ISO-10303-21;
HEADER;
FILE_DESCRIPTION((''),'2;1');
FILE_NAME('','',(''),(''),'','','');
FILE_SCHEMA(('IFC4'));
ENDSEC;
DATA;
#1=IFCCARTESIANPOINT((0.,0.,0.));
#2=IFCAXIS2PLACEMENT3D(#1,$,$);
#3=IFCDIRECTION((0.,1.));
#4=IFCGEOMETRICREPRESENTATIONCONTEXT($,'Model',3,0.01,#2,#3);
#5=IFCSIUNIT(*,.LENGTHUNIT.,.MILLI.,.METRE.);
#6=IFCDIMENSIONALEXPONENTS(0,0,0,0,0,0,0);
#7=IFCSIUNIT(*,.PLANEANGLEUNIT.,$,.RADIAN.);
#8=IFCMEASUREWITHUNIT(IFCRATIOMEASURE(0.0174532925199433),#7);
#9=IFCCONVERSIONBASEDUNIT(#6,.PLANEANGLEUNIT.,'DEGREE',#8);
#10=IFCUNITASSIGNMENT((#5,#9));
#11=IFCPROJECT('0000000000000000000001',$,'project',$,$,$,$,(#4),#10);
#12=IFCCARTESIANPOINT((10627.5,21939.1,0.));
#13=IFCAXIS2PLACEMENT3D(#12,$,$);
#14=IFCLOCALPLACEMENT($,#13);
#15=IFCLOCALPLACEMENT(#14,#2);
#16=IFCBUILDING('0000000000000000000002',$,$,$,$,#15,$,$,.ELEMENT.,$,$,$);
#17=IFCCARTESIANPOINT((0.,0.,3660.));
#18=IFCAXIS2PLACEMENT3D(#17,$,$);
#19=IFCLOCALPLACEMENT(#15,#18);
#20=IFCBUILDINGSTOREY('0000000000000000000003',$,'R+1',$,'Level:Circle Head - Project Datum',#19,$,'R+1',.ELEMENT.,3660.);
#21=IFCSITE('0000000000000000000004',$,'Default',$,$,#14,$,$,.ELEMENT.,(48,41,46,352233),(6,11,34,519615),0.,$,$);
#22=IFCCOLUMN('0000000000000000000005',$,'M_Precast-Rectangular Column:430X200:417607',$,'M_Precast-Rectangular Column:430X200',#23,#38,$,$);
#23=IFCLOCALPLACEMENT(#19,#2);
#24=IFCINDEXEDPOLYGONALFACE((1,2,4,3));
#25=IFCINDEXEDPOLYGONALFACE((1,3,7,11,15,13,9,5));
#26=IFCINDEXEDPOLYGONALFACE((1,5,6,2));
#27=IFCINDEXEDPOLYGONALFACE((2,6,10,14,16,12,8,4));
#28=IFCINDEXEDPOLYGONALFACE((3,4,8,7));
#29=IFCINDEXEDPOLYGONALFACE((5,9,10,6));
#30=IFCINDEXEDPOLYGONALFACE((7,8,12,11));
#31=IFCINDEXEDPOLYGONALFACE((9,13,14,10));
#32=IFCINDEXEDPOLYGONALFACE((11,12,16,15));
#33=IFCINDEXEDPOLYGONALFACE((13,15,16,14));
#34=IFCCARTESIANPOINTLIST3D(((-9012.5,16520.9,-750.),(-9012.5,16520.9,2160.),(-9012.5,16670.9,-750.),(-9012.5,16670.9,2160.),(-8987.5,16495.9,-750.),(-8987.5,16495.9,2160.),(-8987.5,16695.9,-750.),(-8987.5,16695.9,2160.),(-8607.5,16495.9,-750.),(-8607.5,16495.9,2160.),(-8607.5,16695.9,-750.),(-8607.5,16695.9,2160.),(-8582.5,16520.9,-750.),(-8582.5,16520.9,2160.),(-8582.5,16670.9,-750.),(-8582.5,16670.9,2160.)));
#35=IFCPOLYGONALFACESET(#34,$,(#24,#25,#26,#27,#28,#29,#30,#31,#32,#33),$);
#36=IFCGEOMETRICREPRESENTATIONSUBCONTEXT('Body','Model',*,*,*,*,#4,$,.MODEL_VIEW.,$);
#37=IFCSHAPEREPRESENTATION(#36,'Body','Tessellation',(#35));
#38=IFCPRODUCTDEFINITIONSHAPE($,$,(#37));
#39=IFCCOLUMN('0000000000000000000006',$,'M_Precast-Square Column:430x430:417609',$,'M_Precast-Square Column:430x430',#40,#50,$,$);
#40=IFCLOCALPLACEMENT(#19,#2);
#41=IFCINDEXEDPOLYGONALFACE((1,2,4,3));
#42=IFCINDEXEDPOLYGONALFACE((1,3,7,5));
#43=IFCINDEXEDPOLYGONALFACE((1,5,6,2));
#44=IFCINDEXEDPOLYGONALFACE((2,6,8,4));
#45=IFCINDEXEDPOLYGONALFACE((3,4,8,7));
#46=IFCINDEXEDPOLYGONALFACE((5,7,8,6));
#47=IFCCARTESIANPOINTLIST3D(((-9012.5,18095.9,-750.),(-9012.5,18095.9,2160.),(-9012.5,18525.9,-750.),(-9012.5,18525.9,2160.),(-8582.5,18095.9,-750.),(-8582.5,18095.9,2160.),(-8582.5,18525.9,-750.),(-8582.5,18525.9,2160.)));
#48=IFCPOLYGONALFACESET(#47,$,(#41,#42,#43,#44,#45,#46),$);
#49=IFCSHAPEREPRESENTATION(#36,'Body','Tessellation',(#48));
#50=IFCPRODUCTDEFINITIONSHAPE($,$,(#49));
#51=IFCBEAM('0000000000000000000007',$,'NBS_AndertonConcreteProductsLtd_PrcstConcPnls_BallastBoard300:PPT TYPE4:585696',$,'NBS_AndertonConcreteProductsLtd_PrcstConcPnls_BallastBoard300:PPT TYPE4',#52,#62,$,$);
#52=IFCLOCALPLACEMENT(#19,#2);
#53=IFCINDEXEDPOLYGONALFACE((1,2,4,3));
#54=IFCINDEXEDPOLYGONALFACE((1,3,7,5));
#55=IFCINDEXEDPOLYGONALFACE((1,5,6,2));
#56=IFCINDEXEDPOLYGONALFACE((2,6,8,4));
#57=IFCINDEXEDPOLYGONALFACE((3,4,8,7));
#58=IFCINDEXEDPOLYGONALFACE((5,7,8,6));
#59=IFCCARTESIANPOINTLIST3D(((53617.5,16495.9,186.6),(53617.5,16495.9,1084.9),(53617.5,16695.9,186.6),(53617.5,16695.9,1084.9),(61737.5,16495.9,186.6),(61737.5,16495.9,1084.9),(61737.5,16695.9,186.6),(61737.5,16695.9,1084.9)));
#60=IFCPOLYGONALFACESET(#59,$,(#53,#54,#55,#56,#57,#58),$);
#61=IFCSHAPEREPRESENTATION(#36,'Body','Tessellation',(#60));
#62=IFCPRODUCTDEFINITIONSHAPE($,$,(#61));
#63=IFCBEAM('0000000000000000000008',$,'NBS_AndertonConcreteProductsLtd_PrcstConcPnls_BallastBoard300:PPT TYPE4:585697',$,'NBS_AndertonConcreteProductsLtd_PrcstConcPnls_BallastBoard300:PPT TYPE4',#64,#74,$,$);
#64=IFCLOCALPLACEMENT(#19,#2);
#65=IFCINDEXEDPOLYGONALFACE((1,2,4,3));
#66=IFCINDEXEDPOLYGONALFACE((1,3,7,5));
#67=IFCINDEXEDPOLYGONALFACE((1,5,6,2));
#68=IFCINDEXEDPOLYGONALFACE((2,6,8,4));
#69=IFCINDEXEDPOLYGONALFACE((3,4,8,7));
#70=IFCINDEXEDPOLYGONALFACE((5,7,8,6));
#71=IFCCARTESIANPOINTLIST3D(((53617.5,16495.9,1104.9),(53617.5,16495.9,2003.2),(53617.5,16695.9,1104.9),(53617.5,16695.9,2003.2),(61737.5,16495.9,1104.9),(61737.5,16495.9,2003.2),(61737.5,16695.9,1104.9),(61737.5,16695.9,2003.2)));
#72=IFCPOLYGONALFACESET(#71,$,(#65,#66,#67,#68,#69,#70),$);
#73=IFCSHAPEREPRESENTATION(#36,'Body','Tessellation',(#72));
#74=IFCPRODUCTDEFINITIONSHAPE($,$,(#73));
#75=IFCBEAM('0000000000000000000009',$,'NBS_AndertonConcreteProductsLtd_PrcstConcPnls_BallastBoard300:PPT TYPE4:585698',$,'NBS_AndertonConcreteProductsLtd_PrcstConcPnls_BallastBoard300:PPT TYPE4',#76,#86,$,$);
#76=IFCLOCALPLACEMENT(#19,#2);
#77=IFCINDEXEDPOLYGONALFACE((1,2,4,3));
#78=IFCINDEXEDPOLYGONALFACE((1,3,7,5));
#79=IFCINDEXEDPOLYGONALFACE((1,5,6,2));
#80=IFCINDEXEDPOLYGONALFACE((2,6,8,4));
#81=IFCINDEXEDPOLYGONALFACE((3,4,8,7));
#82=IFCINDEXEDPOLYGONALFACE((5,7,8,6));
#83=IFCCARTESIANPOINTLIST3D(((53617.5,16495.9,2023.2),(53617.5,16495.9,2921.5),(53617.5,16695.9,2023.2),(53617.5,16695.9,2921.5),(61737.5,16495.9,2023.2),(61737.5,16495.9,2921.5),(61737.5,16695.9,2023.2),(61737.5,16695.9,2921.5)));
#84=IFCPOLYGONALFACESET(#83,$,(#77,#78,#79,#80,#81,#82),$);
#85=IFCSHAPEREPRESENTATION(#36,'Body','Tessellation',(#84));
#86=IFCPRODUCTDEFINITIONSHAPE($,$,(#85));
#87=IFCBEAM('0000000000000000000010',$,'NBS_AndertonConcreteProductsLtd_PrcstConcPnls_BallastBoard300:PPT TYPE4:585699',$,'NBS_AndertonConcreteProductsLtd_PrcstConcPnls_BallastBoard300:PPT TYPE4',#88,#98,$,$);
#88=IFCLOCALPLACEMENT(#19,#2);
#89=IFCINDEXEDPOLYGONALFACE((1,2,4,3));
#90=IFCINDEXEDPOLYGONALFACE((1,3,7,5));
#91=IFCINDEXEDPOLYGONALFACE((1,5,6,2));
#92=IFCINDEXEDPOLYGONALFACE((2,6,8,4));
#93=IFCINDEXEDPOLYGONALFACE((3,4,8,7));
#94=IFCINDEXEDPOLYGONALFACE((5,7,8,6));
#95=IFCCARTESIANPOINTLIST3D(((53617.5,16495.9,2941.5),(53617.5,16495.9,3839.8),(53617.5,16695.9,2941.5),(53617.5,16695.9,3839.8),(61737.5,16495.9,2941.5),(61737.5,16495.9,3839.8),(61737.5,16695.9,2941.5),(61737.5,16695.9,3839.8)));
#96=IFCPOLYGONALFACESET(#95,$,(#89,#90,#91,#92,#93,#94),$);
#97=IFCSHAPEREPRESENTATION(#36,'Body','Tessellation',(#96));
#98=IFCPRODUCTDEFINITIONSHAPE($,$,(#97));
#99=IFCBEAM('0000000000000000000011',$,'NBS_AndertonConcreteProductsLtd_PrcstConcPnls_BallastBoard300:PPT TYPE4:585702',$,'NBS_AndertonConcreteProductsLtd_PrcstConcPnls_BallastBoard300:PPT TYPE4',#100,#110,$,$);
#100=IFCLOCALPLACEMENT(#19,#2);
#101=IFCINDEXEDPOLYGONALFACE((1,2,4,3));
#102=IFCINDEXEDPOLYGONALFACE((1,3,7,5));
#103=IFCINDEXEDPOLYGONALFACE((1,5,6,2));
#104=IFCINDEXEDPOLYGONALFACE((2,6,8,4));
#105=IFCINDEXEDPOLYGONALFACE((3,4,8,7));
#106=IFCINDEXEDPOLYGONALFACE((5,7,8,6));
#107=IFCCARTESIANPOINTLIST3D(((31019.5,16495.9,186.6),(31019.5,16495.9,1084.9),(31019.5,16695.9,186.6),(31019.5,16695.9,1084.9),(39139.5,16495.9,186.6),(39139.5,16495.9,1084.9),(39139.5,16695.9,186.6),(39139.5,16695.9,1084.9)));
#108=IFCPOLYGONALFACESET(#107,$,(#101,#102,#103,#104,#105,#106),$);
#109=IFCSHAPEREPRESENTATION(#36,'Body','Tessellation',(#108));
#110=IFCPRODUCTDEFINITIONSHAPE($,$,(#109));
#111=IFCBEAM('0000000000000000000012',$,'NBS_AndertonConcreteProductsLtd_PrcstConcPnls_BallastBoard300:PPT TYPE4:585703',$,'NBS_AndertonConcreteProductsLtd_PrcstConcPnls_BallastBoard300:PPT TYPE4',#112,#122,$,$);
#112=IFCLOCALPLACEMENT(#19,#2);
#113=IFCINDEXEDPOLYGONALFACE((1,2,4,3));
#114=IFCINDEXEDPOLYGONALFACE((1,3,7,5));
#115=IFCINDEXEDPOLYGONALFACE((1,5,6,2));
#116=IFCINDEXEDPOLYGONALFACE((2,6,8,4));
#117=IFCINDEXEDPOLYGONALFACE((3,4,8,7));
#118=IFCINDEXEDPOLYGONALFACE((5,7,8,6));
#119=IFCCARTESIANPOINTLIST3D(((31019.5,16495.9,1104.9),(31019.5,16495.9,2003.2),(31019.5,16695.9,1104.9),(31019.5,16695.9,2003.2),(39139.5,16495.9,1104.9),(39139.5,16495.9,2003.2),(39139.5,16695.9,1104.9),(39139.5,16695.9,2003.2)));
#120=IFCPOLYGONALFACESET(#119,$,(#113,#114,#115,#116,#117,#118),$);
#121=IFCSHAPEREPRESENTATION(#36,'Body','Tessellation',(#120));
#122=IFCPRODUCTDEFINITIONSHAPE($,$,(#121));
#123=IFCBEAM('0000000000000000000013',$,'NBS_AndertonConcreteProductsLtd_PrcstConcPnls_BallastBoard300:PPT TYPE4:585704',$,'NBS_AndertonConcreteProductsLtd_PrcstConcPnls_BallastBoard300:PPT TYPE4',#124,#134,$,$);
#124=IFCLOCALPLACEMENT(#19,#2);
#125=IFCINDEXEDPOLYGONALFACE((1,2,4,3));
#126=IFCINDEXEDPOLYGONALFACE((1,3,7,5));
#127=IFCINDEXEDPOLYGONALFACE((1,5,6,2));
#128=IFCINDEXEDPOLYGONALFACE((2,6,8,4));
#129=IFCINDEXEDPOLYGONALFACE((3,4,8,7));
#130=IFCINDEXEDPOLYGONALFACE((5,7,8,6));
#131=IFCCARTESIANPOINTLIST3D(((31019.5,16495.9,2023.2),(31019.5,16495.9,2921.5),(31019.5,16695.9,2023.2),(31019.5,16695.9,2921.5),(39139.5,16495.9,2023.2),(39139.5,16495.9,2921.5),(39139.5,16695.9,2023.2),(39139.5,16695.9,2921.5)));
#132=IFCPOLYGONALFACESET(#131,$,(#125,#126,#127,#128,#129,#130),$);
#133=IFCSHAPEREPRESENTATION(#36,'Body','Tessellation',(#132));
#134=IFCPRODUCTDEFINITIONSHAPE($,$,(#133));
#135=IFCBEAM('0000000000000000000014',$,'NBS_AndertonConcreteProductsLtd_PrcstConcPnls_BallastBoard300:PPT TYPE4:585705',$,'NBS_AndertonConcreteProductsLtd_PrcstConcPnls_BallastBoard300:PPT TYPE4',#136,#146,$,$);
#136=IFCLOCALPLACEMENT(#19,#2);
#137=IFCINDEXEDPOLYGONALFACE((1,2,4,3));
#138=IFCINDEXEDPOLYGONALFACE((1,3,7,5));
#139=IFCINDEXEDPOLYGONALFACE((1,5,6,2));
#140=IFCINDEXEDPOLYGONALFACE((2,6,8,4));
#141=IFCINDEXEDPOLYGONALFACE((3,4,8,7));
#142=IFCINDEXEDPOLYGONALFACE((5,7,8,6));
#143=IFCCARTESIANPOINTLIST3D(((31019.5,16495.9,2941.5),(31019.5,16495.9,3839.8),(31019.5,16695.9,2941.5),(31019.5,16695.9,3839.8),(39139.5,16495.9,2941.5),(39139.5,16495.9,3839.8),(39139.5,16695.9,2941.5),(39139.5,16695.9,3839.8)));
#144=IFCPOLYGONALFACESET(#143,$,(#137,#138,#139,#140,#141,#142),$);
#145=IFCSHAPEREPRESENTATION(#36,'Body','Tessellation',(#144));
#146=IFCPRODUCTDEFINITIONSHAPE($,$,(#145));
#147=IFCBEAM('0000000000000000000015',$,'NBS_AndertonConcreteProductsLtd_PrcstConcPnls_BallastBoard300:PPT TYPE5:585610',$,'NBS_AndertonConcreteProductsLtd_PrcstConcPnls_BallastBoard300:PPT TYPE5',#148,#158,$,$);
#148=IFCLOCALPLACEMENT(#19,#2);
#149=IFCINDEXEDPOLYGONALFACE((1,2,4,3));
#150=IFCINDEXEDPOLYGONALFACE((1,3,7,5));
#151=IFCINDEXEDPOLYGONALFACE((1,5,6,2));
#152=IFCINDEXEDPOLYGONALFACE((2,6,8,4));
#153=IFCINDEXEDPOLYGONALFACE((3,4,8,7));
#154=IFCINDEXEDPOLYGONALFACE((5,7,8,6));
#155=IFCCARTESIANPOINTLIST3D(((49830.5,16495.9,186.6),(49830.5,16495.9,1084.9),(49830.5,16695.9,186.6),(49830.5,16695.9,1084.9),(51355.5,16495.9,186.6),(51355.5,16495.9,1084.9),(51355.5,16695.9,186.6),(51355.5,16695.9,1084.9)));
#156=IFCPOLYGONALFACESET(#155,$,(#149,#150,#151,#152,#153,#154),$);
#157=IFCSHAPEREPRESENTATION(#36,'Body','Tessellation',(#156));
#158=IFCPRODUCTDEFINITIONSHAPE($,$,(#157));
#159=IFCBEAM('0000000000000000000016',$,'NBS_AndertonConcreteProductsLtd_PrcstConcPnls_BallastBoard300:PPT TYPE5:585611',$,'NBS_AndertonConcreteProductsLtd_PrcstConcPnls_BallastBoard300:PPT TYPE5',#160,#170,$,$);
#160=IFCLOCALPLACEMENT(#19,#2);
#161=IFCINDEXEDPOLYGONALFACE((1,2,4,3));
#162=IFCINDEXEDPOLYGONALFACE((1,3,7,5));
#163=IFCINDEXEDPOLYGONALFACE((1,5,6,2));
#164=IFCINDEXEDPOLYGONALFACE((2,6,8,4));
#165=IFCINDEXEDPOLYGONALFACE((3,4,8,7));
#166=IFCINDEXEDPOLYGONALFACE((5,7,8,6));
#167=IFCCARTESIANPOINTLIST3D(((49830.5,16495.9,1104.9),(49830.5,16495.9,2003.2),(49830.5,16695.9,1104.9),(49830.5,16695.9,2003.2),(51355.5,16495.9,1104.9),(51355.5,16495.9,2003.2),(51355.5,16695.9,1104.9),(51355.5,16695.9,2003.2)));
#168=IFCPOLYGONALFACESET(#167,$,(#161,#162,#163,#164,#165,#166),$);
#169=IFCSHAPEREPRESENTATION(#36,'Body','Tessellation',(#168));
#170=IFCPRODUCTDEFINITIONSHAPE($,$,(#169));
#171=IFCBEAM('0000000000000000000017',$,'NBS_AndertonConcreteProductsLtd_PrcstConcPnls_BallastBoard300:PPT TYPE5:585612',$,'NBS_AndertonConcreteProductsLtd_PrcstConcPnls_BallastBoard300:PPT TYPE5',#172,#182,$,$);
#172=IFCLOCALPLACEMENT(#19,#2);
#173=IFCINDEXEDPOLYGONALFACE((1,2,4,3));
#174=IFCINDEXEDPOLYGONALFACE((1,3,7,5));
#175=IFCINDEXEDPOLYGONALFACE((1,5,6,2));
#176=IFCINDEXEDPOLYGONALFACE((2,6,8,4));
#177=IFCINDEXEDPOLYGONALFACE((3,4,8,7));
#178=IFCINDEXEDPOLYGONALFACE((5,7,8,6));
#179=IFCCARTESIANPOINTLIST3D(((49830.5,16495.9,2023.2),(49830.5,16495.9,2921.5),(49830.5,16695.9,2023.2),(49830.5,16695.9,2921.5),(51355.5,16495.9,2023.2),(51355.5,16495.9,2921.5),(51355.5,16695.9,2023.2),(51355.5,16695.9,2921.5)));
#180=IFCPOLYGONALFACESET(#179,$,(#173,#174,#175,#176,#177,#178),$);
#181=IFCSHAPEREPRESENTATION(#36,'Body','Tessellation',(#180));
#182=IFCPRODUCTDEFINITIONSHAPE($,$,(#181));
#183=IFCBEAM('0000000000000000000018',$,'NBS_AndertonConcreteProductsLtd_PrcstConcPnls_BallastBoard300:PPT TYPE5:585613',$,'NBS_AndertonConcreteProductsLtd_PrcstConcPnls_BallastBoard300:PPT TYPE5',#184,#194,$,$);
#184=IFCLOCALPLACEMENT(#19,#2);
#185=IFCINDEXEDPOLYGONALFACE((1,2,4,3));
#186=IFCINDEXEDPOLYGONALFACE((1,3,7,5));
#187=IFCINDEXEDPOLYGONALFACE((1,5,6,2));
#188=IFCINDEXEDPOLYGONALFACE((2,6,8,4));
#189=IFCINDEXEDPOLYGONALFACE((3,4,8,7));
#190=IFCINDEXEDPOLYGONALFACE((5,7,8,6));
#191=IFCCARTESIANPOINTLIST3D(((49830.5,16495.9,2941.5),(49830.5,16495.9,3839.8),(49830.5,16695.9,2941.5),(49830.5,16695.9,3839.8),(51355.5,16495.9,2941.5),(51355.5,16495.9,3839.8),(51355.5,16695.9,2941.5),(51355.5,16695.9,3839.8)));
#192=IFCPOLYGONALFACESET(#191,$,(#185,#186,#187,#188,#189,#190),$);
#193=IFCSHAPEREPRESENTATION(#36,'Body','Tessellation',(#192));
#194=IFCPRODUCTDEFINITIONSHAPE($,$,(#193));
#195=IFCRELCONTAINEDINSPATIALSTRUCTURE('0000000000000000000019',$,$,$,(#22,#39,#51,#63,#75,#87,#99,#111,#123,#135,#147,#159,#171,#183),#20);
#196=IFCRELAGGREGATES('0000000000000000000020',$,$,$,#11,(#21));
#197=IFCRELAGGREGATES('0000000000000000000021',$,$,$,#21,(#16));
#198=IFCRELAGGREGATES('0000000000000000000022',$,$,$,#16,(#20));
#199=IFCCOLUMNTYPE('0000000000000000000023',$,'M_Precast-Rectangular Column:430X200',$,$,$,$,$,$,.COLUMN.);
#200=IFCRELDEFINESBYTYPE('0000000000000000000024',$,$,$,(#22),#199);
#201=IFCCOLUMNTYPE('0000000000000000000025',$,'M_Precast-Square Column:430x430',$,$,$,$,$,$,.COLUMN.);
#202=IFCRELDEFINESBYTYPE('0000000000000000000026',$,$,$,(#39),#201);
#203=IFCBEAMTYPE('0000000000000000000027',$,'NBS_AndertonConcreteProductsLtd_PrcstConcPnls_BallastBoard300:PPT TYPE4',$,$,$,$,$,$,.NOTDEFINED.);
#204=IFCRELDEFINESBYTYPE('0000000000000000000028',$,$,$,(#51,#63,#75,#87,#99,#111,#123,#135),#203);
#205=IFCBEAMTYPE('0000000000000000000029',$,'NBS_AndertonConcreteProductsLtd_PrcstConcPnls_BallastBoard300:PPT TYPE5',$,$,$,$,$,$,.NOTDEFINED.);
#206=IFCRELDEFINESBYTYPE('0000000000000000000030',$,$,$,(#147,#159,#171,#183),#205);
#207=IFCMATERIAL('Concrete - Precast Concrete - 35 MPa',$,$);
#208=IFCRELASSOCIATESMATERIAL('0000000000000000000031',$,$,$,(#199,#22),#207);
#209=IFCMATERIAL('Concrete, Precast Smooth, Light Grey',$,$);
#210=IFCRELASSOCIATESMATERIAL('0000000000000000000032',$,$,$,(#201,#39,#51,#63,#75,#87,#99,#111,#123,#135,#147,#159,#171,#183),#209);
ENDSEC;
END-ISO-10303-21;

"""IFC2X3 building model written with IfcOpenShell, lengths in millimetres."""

from ifc_helpers import new_model, entity, si_unit, converted_unit, direction, frame, frame_2d, origin, origin_2d_with_axis, place, context, subcontext, project, spatial, polyline, rectangle, outline, extrude, source, transform, mapped, material, type_object, type_shapes, element, save


model = new_model("IFC2X3")

# Units and contexts
model_context = context("Model", 3, precision=0.01, world=origin(), true_north=direction((0.0, 1.0)))
body_context = subcontext(model_context, "Body", "Model", "MODEL_VIEW")
ifc_project = project(units=[si_unit("LENGTHUNIT", "METRE", prefix="MILLI"), converted_unit("PLANEANGLEUNIT", "DEGREE", entity("IfcRatioMeasure", 0.0174532925199433), si_unit("PLANEANGLEUNIT", "RADIAN"), dimensions=[0, 0, 0, 0, 0, 0, 0])], contexts=[model_context])

# Site, building, storey
site_placement = place(None, frame((10627.5, 21939.1, 0.0)))
site = spatial("IfcSite", under=ifc_project, at=site_placement, Name="Default", CompositionType="ELEMENT", RefLatitude=(48, 41, 46, 352233), RefLongitude=(6, 11, 34, 519615), RefElevation=0.0)
building_placement = place(site_placement, origin())
building = spatial("IfcBuilding", under=site, at=building_placement, CompositionType="ELEMENT")
storey_placement = place(building_placement, frame((0.0, 0.0, 3660.0)))
storey = spatial("IfcBuildingStorey", under=building, at=storey_placement, Name="R+1", ObjectType="Level:Circle Head - Project Datum", LongName="R+1", CompositionType="ELEMENT", Elevation=3660.0)

# Columns
ifc_material_1 = material(Name="Concrete - Precast Concrete - 35 MPa")
column_type_1 = type_object("IfcColumnType", Name="M_Precast-Rectangular Column:430X200", PredefinedType="COLUMN", material=ifc_material_1)
shared_shape_1 = source(origin(), body_context, "Body", "SweptSolid", [
    extrude(outline(polyline([(-75.0, -215.0), (75.0, -215.0), (100.0, -190.0), (100.0, 190.0), (75.0, 215.0), (-75.0, 215.0), (-100.0, 190.0), (-100.0, -190.0), (-75.0, -215.0)])), frame((0.0, 0.0, 2910.0), z_axis=(0.0, 0.0, 1.0), x_axis=(0.0, -1.0, 0.0)), (0.0, 0.0, 1.0), 2910.0),
])
type_shapes(column_type_1, [shared_shape_1])
column_1_placement = place(storey_placement, frame((-8797.5, 16595.9, -3660.0), z_axis=(0.0, 0.0, 1.0), x_axis=(-1.0, 0.0, 0.0)))
element("IfcColumn", 1, at=column_1_placement, inside=storey, type_object=column_type_1, material=ifc_material_1, Name="M_Precast-Rectangular Column:430X200:417607", ObjectType="M_Precast-Rectangular Column:430X200", context=body_context, shape_type="MappedRepresentation", body=[
    mapped(shared_shape_1, transform((0.0, 0.0, 0.0), scale=1.0)),
])
ifc_material_2 = material(Name="Concrete, Precast Smooth, Light Grey")
column_type_2 = type_object("IfcColumnType", Name="M_Precast-Square Column:430x430", PredefinedType="COLUMN", material=ifc_material_2)
shared_shape_2 = source(origin(), body_context, "Body", "SweptSolid", [
    extrude(rectangle(XDim=430.0, YDim=430.0, at=origin_2d_with_axis()), frame((0.0, 0.0, 2910.0), z_axis=(0.0, 0.0, 1.0), x_axis=(0.0, -1.0, 0.0)), (0.0, 0.0, 1.0), 2910.0),
])
type_shapes(column_type_2, [shared_shape_2])
column_2_placement = place(storey_placement, frame((-8797.5, 18310.9, -3660.0), z_axis=(0.0, 0.0, 1.0), x_axis=(-1.0, 0.0, 0.0)))
element("IfcColumn", 2, at=column_2_placement, inside=storey, type_object=column_type_2, material=ifc_material_2, Name="M_Precast-Square Column:430x430:417609", ObjectType="M_Precast-Square Column:430x430", context=body_context, shape_type="MappedRepresentation", body=[
    mapped(shared_shape_2, transform((0.0, 0.0, 0.0), scale=1.0)),
])

# Beams
beam_type_1 = type_object("IfcBeamType", Name="NBS_AndertonConcreteProductsLtd_PrcstConcPnls_BallastBoard300:PPT TYPE4", PredefinedType="NOTDEFINED")
beam_1_placement = place(storey_placement, origin())
element("IfcBeam", 3, at=beam_1_placement, inside=storey, type_object=beam_type_1, material=ifc_material_2, Name="NBS_AndertonConcreteProductsLtd_PrcstConcPnls_BallastBoard300:PPT TYPE4:585696", ObjectType="NBS_AndertonConcreteProductsLtd_PrcstConcPnls_BallastBoard300:PPT TYPE4", context=body_context, shape_type="SweptSolid", body=[
    extrude(rectangle(XDim=898.3, YDim=200.0, at=frame_2d((0.0, 0.0), x_axis=(1.0, 0.0))), frame((53617.5, 16595.9, 635.8), z_axis=(1.0, 0.0, 0.0), x_axis=(0.0, 0.0, -1.0)), (0.0, 0.0, 1.0), 8120.0),
])
beam_2_placement = place(storey_placement, origin())
element("IfcBeam", 4, at=beam_2_placement, inside=storey, type_object=beam_type_1, material=ifc_material_2, Name="NBS_AndertonConcreteProductsLtd_PrcstConcPnls_BallastBoard300:PPT TYPE4:585697", ObjectType="NBS_AndertonConcreteProductsLtd_PrcstConcPnls_BallastBoard300:PPT TYPE4", context=body_context, shape_type="SweptSolid", body=[
    extrude(rectangle(XDim=898.3, YDim=200.0, at=frame_2d((0.0, 0.0), x_axis=(1.0, 0.0))), frame((53617.5, 16595.9, 1554.1), z_axis=(1.0, 0.0, 0.0), x_axis=(0.0, 0.0, -1.0)), (0.0, 0.0, 1.0), 8120.0),
])
beam_3_placement = place(storey_placement, origin())
element("IfcBeam", 5, at=beam_3_placement, inside=storey, type_object=beam_type_1, material=ifc_material_2, Name="NBS_AndertonConcreteProductsLtd_PrcstConcPnls_BallastBoard300:PPT TYPE4:585698", ObjectType="NBS_AndertonConcreteProductsLtd_PrcstConcPnls_BallastBoard300:PPT TYPE4", context=body_context, shape_type="SweptSolid", body=[
    extrude(rectangle(XDim=898.3, YDim=200.0, at=frame_2d((0.0, 0.0), x_axis=(1.0, 0.0))), frame((53617.5, 16595.9, 2472.4), z_axis=(1.0, 0.0, 0.0), x_axis=(0.0, 0.0, -1.0)), (0.0, 0.0, 1.0), 8120.0),
])
beam_4_placement = place(storey_placement, origin())
element("IfcBeam", 6, at=beam_4_placement, inside=storey, type_object=beam_type_1, material=ifc_material_2, Name="NBS_AndertonConcreteProductsLtd_PrcstConcPnls_BallastBoard300:PPT TYPE4:585699", ObjectType="NBS_AndertonConcreteProductsLtd_PrcstConcPnls_BallastBoard300:PPT TYPE4", context=body_context, shape_type="SweptSolid", body=[
    extrude(rectangle(XDim=898.3, YDim=200.0, at=frame_2d((0.0, 0.0), x_axis=(1.0, 0.0))), frame((53617.5, 16595.9, 3390.7), z_axis=(1.0, 0.0, 0.0), x_axis=(0.0, 0.0, -1.0)), (0.0, 0.0, 1.0), 8120.0),
])
beam_5_placement = place(storey_placement, origin())
element("IfcBeam", 7, at=beam_5_placement, inside=storey, type_object=beam_type_1, material=ifc_material_2, Name="NBS_AndertonConcreteProductsLtd_PrcstConcPnls_BallastBoard300:PPT TYPE4:585702", ObjectType="NBS_AndertonConcreteProductsLtd_PrcstConcPnls_BallastBoard300:PPT TYPE4", context=body_context, shape_type="SweptSolid", body=[
    extrude(rectangle(XDim=898.3, YDim=200.0, at=frame_2d((0.0, 0.0), x_axis=(1.0, 0.0))), frame((31019.5, 16595.9, 635.8), z_axis=(1.0, 0.0, 0.0), x_axis=(0.0, 0.0, -1.0)), (0.0, 0.0, 1.0), 8120.0),
])
beam_6_placement = place(storey_placement, origin())
element("IfcBeam", 8, at=beam_6_placement, inside=storey, type_object=beam_type_1, material=ifc_material_2, Name="NBS_AndertonConcreteProductsLtd_PrcstConcPnls_BallastBoard300:PPT TYPE4:585703", ObjectType="NBS_AndertonConcreteProductsLtd_PrcstConcPnls_BallastBoard300:PPT TYPE4", context=body_context, shape_type="SweptSolid", body=[
    extrude(rectangle(XDim=898.3, YDim=200.0, at=frame_2d((0.0, 0.0), x_axis=(1.0, 0.0))), frame((31019.5, 16595.9, 1554.1), z_axis=(1.0, 0.0, 0.0), x_axis=(0.0, 0.0, -1.0)), (0.0, 0.0, 1.0), 8120.0),
])
beam_7_placement = place(storey_placement, origin())
element("IfcBeam", 9, at=beam_7_placement, inside=storey, type_object=beam_type_1, material=ifc_material_2, Name="NBS_AndertonConcreteProductsLtd_PrcstConcPnls_BallastBoard300:PPT TYPE4:585704", ObjectType="NBS_AndertonConcreteProductsLtd_PrcstConcPnls_BallastBoard300:PPT TYPE4", context=body_context, shape_type="SweptSolid", body=[
    extrude(rectangle(XDim=898.3, YDim=200.0, at=frame_2d((0.0, 0.0), x_axis=(1.0, 0.0))), frame((31019.5, 16595.9, 2472.4), z_axis=(1.0, 0.0, 0.0), x_axis=(0.0, 0.0, -1.0)), (0.0, 0.0, 1.0), 8120.0),
])
beam_8_placement = place(storey_placement, origin())
element("IfcBeam", 10, at=beam_8_placement, inside=storey, type_object=beam_type_1, material=ifc_material_2, Name="NBS_AndertonConcreteProductsLtd_PrcstConcPnls_BallastBoard300:PPT TYPE4:585705", ObjectType="NBS_AndertonConcreteProductsLtd_PrcstConcPnls_BallastBoard300:PPT TYPE4", context=body_context, shape_type="SweptSolid", body=[
    extrude(rectangle(XDim=898.3, YDim=200.0, at=frame_2d((0.0, 0.0), x_axis=(1.0, 0.0))), frame((31019.5, 16595.9, 3390.7), z_axis=(1.0, 0.0, 0.0), x_axis=(0.0, 0.0, -1.0)), (0.0, 0.0, 1.0), 8120.0),
])
beam_type_2 = type_object("IfcBeamType", Name="NBS_AndertonConcreteProductsLtd_PrcstConcPnls_BallastBoard300:PPT TYPE5", PredefinedType="NOTDEFINED")
beam_9_placement = place(storey_placement, origin())
element("IfcBeam", 11, at=beam_9_placement, inside=storey, type_object=beam_type_2, material=ifc_material_2, Name="NBS_AndertonConcreteProductsLtd_PrcstConcPnls_BallastBoard300:PPT TYPE5:585610", ObjectType="NBS_AndertonConcreteProductsLtd_PrcstConcPnls_BallastBoard300:PPT TYPE5", context=body_context, shape_type="SweptSolid", body=[
    extrude(rectangle(XDim=898.3, YDim=200.0, at=frame_2d((0.0, 0.0), x_axis=(1.0, 0.0))), frame((49830.5, 16595.9, 635.8), z_axis=(1.0, 0.0, 0.0), x_axis=(0.0, 0.0, -1.0)), (0.0, 0.0, 1.0), 1525.0),
])
beam_10_placement = place(storey_placement, origin())
element("IfcBeam", 12, at=beam_10_placement, inside=storey, type_object=beam_type_2, material=ifc_material_2, Name="NBS_AndertonConcreteProductsLtd_PrcstConcPnls_BallastBoard300:PPT TYPE5:585611", ObjectType="NBS_AndertonConcreteProductsLtd_PrcstConcPnls_BallastBoard300:PPT TYPE5", context=body_context, shape_type="SweptSolid", body=[
    extrude(rectangle(XDim=898.3, YDim=200.0, at=frame_2d((0.0, 0.0), x_axis=(1.0, 0.0))), frame((49830.5, 16595.9, 1554.1), z_axis=(1.0, 0.0, 0.0), x_axis=(0.0, 0.0, -1.0)), (0.0, 0.0, 1.0), 1525.0),
])
beam_11_placement = place(storey_placement, origin())
element("IfcBeam", 13, at=beam_11_placement, inside=storey, type_object=beam_type_2, material=ifc_material_2, Name="NBS_AndertonConcreteProductsLtd_PrcstConcPnls_BallastBoard300:PPT TYPE5:585612", ObjectType="NBS_AndertonConcreteProductsLtd_PrcstConcPnls_BallastBoard300:PPT TYPE5", context=body_context, shape_type="SweptSolid", body=[
    extrude(rectangle(XDim=898.3, YDim=200.0, at=frame_2d((0.0, 0.0), x_axis=(1.0, 0.0))), frame((49830.5, 16595.9, 2472.4), z_axis=(1.0, 0.0, 0.0), x_axis=(0.0, 0.0, -1.0)), (0.0, 0.0, 1.0), 1525.0),
])
beam_12_placement = place(storey_placement, origin())
element("IfcBeam", 14, at=beam_12_placement, inside=storey, type_object=beam_type_2, material=ifc_material_2, Name="NBS_AndertonConcreteProductsLtd_PrcstConcPnls_BallastBoard300:PPT TYPE5:585613", ObjectType="NBS_AndertonConcreteProductsLtd_PrcstConcPnls_BallastBoard300:PPT TYPE5", context=body_context, shape_type="SweptSolid", body=[
    extrude(rectangle(XDim=898.3, YDim=200.0, at=frame_2d((0.0, 0.0), x_axis=(1.0, 0.0))), frame((49830.5, 16595.9, 3390.7), z_axis=(1.0, 0.0, 0.0), x_axis=(0.0, 0.0, -1.0)), (0.0, 0.0, 1.0), 1525.0),
])

save(model, "model.ifc")
